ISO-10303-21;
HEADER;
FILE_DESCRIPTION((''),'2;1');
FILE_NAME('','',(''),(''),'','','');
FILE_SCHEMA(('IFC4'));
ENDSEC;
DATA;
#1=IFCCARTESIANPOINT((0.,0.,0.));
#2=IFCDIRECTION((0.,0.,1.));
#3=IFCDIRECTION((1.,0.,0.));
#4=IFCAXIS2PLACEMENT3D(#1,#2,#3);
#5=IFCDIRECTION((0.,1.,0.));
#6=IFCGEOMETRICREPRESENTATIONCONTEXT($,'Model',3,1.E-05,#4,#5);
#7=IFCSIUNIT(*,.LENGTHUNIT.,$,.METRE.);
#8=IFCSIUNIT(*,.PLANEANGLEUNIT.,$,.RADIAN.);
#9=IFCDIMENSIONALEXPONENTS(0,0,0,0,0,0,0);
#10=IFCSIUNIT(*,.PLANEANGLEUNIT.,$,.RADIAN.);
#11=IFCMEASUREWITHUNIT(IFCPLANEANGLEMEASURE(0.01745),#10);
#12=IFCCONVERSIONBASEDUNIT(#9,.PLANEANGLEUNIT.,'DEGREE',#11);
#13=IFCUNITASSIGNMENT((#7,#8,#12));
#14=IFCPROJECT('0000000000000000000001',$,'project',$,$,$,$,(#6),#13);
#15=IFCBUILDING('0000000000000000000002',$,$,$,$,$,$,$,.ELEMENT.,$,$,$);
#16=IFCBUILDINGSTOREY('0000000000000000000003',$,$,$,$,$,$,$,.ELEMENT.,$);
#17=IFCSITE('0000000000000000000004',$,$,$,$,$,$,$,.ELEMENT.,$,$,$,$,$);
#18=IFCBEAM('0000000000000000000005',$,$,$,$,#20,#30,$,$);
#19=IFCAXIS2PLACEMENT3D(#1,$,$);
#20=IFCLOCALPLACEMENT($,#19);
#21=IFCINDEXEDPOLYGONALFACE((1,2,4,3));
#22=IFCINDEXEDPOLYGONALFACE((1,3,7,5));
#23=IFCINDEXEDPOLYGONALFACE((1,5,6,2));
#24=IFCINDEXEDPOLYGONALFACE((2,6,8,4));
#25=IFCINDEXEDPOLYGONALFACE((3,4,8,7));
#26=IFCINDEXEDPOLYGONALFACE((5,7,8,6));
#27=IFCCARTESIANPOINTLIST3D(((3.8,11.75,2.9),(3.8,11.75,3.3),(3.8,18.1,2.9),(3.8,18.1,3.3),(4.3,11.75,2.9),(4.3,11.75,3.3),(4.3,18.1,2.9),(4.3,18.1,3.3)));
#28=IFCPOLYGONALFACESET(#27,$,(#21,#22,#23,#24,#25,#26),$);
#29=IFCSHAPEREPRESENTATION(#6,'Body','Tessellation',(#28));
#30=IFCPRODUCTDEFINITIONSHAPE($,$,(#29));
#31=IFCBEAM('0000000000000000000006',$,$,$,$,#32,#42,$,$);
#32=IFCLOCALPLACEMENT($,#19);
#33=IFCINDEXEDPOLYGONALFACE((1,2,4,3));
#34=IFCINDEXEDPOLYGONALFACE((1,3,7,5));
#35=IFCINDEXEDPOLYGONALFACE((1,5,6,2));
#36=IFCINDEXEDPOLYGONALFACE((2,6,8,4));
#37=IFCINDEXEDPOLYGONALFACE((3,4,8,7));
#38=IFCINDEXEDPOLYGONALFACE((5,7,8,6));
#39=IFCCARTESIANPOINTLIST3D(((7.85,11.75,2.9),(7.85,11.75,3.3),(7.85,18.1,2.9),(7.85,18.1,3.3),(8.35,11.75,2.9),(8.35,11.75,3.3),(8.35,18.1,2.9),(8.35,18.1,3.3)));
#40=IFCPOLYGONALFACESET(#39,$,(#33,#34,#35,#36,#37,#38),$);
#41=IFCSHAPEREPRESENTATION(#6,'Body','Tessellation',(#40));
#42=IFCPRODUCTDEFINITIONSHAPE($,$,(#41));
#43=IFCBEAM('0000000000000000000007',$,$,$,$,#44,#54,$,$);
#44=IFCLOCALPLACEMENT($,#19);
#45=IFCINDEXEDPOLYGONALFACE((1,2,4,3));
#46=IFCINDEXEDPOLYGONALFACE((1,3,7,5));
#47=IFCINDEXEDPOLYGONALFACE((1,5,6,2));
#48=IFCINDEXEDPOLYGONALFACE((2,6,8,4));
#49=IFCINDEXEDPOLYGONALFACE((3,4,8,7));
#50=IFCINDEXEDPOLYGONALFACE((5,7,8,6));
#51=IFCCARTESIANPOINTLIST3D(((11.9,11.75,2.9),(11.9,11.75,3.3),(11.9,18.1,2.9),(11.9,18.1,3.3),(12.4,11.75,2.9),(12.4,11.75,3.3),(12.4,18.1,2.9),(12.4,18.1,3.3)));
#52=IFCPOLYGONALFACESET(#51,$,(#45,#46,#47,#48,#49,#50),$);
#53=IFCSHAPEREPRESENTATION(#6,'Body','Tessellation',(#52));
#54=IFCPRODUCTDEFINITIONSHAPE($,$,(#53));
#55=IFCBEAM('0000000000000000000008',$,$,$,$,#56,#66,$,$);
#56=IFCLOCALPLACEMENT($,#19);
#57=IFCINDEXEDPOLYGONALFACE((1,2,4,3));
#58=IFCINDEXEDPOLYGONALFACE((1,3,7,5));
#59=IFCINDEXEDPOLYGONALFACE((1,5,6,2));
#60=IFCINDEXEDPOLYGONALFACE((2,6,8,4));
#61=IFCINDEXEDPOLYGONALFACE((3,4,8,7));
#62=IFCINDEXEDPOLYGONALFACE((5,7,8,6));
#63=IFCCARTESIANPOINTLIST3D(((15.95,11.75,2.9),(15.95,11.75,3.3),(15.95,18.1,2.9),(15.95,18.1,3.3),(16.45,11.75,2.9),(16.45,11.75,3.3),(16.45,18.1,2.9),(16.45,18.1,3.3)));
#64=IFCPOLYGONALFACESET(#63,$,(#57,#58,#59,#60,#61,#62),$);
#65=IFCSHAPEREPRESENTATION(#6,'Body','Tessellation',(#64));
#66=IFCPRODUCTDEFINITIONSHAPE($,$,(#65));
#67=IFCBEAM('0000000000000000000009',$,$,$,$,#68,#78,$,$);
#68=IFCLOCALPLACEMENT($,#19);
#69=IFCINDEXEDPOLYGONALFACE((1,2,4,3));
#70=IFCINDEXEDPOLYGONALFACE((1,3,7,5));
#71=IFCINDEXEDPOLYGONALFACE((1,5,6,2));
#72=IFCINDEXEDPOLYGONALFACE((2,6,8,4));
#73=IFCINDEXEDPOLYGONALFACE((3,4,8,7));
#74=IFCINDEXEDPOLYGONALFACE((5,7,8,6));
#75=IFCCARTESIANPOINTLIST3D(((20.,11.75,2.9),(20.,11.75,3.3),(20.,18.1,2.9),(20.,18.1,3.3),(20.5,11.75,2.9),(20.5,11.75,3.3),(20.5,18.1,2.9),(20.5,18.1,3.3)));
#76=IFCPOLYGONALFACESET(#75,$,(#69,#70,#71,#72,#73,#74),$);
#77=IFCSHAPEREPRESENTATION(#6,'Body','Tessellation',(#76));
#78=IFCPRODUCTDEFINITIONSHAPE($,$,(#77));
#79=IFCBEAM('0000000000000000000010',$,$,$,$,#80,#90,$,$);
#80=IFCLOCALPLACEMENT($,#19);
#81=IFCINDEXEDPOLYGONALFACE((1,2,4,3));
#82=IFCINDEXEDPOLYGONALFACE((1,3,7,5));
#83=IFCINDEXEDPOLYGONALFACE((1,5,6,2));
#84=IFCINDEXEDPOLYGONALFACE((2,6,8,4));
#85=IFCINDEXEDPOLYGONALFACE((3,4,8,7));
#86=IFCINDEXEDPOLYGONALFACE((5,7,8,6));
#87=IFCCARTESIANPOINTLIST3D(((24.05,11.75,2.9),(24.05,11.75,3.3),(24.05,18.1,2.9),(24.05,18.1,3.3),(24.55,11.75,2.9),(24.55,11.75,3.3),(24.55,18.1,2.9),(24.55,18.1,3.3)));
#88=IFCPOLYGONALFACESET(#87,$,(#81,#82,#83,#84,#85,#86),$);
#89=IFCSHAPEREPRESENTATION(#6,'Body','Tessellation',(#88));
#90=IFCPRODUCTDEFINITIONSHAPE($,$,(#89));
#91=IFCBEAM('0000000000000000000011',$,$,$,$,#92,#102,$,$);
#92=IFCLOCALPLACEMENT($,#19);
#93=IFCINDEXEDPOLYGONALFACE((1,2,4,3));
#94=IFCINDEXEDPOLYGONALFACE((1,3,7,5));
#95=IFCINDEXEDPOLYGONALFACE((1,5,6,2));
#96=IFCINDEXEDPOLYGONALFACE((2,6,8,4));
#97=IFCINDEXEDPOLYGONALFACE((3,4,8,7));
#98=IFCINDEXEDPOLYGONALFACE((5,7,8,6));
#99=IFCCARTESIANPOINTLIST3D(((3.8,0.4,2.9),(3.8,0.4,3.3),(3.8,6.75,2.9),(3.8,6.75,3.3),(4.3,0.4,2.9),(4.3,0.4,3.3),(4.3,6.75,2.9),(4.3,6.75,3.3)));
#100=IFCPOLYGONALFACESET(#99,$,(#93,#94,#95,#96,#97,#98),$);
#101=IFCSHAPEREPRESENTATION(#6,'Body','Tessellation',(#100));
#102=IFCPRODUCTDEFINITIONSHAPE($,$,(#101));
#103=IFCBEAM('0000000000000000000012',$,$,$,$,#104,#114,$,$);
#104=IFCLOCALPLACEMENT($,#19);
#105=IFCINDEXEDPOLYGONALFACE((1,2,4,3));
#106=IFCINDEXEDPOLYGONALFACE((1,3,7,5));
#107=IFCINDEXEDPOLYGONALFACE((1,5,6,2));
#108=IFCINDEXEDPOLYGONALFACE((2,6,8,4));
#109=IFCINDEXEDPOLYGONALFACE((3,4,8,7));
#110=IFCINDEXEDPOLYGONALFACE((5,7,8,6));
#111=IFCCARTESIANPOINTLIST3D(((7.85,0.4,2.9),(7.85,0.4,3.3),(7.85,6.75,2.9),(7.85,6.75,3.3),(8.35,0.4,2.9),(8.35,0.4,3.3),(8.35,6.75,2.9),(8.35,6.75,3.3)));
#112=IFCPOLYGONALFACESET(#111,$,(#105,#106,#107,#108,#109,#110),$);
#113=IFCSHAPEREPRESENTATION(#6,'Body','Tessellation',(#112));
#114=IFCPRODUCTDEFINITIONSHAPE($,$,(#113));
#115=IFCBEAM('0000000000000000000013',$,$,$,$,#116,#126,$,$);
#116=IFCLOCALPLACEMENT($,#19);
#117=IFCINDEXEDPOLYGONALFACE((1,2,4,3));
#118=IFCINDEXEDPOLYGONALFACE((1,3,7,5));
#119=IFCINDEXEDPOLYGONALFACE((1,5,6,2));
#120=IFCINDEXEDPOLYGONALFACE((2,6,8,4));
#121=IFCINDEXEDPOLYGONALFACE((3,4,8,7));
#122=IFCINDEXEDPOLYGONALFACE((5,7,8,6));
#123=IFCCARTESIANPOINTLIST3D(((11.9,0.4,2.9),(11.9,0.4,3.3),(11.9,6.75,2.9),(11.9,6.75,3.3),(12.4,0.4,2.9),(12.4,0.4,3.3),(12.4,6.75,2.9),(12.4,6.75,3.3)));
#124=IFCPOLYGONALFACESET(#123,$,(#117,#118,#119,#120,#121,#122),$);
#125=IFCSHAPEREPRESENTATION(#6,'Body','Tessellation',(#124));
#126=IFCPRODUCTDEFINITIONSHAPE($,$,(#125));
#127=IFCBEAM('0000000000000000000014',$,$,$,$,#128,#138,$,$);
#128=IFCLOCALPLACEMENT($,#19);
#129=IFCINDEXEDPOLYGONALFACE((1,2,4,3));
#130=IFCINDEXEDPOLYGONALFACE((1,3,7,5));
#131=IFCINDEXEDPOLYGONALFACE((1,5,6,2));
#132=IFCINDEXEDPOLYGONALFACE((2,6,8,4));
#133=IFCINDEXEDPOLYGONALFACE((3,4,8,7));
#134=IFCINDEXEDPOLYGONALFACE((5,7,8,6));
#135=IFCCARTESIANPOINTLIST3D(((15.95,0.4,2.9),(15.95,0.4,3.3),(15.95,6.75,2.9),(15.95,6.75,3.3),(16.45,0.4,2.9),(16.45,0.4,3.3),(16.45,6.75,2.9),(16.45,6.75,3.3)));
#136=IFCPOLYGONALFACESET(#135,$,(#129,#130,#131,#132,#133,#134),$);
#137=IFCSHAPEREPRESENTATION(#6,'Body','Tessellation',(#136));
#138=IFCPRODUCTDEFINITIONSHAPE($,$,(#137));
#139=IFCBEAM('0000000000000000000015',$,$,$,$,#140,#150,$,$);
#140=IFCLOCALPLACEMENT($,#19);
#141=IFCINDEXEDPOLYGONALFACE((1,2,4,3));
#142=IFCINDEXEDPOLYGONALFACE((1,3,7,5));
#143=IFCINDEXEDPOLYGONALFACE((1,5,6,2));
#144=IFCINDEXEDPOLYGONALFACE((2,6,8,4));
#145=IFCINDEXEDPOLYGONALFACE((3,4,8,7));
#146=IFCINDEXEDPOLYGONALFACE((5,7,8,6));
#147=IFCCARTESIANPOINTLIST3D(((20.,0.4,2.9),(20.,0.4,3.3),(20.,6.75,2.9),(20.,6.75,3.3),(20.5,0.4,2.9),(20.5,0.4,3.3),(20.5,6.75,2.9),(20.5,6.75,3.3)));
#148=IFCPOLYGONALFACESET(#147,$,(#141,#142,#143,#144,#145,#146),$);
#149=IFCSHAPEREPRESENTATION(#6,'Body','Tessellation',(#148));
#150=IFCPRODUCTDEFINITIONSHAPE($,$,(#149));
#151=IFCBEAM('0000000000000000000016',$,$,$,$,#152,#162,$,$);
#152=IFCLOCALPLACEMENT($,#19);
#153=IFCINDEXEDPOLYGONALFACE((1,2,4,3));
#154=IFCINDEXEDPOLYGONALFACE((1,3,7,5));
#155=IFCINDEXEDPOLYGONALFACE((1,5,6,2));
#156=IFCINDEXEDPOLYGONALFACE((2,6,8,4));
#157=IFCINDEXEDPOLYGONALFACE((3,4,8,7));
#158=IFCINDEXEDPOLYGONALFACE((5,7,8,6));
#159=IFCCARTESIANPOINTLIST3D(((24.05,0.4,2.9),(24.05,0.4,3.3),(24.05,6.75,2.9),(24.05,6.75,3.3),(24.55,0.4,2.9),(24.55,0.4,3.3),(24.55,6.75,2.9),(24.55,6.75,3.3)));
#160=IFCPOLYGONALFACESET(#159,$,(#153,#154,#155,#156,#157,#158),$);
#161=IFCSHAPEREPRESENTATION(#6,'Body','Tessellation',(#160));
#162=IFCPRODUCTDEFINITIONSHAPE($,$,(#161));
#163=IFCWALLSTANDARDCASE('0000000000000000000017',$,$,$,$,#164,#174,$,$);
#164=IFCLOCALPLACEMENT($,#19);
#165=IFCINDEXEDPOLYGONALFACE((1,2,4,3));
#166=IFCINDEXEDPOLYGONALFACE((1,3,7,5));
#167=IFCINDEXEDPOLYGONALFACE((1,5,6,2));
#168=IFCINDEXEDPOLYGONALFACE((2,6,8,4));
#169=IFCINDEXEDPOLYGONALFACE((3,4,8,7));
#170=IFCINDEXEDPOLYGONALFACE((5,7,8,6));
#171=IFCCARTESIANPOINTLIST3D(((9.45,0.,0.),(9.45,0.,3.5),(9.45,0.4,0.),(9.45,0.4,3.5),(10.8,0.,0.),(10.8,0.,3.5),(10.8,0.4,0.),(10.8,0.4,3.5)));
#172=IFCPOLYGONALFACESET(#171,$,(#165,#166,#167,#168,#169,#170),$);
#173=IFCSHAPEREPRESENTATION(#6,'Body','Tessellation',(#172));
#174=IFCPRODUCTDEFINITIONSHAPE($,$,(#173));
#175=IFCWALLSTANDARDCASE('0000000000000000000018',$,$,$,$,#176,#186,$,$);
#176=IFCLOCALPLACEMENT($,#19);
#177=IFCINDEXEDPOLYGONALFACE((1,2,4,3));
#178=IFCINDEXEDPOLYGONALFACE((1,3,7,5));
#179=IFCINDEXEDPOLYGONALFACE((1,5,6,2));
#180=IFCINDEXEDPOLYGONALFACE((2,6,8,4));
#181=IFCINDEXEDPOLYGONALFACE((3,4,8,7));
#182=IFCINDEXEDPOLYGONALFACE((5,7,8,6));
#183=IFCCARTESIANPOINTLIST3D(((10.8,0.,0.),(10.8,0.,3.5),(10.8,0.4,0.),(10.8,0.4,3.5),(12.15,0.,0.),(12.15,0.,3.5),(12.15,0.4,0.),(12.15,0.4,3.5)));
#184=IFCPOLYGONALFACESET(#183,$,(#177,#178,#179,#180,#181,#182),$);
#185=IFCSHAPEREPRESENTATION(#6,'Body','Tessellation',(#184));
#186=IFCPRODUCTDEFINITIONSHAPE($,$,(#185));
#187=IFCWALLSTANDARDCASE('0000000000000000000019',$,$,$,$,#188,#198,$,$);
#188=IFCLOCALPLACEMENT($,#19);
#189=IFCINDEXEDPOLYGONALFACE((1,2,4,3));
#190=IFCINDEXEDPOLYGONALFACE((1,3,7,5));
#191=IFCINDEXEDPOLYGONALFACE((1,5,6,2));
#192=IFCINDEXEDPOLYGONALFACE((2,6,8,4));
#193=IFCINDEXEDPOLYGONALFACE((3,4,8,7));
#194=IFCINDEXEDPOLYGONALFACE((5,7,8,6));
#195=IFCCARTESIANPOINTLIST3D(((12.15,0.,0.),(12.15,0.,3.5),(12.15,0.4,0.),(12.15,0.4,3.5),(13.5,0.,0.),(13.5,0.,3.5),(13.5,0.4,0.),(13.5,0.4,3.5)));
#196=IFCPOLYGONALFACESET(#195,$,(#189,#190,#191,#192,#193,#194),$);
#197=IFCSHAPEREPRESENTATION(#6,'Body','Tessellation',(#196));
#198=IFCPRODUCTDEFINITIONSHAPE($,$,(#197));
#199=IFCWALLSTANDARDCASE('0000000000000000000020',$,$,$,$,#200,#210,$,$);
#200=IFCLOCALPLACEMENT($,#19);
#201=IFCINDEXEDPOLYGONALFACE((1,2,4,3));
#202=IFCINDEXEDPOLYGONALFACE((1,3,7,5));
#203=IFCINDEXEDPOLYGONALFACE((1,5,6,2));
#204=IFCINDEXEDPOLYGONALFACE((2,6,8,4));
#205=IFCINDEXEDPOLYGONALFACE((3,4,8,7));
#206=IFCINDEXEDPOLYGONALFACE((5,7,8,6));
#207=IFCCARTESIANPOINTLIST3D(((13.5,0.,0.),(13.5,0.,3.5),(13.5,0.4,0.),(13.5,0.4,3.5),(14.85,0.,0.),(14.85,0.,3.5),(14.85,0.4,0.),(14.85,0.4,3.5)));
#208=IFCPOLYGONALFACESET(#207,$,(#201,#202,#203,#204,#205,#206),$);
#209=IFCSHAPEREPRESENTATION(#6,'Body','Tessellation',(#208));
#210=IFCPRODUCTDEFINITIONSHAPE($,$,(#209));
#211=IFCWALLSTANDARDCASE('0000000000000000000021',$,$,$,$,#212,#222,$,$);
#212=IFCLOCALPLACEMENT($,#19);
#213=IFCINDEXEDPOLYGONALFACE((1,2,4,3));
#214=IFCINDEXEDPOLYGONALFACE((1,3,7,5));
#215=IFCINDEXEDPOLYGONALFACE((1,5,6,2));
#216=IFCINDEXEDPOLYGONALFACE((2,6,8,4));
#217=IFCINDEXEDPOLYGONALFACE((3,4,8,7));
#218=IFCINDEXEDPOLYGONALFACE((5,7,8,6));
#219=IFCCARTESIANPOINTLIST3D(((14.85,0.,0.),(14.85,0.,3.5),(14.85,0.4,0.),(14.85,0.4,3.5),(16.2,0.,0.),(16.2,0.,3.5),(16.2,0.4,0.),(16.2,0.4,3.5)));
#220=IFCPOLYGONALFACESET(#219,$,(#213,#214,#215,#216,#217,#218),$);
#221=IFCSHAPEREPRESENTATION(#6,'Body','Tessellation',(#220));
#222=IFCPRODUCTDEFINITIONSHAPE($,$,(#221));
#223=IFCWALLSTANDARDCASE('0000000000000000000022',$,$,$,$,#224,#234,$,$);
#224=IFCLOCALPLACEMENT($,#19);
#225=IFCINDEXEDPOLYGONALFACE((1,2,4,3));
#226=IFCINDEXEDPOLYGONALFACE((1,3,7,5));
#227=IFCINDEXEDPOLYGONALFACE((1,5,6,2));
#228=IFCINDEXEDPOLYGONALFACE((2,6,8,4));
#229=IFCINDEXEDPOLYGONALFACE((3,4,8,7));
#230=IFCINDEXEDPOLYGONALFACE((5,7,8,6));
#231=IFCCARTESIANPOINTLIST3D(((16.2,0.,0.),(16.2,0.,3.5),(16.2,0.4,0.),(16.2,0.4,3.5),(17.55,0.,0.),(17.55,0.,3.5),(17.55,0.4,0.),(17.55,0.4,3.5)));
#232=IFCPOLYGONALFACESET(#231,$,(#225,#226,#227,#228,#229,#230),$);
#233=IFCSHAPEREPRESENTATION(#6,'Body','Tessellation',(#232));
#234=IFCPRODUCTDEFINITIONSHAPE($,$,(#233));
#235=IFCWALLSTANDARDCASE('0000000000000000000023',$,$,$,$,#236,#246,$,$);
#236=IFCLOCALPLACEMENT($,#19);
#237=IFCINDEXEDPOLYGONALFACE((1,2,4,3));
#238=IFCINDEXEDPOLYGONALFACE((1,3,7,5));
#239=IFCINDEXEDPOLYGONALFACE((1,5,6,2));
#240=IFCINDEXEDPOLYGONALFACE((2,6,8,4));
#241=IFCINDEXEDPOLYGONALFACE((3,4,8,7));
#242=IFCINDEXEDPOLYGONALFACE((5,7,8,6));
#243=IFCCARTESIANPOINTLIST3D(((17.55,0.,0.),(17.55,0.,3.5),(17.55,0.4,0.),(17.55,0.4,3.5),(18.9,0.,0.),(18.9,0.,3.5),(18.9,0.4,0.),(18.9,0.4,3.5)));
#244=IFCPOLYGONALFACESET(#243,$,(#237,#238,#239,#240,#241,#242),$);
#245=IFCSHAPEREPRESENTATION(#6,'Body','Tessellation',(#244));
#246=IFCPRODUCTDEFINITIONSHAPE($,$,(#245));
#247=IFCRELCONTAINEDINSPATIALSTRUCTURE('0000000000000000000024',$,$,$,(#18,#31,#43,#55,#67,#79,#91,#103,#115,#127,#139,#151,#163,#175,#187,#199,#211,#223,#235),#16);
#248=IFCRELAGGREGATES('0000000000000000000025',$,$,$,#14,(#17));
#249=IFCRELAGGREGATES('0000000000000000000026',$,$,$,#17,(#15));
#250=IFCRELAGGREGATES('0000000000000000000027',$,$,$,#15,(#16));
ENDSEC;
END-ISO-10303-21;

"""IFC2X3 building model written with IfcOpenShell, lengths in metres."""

from ifc_helpers import new_model, entity, si_unit, converted_unit, direction, frame, origin_with_axes, place, context, project, spatial, polyline, outline, extrude, element, save


model = new_model("IFC2X3")

# Units and contexts
model_context = context("Model", 3, precision=1e-05, world=origin_with_axes(), true_north=direction((0.0, 1.0, 0.0)))
ifc_project = project(units=[si_unit("LENGTHUNIT", "METRE"), si_unit("PLANEANGLEUNIT", "RADIAN"), converted_unit("PLANEANGLEUNIT", "DEGREE", entity("IfcPlaneAngleMeasure", 0.01745), si_unit("PLANEANGLEUNIT", "RADIAN"), dimensions=[0, 0, 0, 0, 0, 0, 0])], contexts=[model_context])

# Site, building, storey
site = spatial("IfcSite", under=ifc_project, CompositionType="ELEMENT")
building = spatial("IfcBuilding", under=site, CompositionType="ELEMENT")
storey = spatial("IfcBuildingStorey", under=building, CompositionType="ELEMENT")

# Beams
for number, where, z_axis, x_axis in (
    (1, (4.05, 18.1, 3.1), (0.0, -1.0, 0.0), (-1.0, 0.0, 0.0)),
    (2, (8.1, 18.1, 3.1), (0.0, -1.0, 0.0), (-1.0, 0.0, 0.0)),
    (3, (12.15, 18.1, 3.1), (0.0, -1.0, 0.0), (-1.0, 0.0, 0.0)),
    (4, (16.2, 18.1, 3.1), (0.0, -1.0, 0.0), (-1.0, 0.0, 0.0)),
    (5, (20.25, 18.1, 3.1), (0.0, -1.0, 0.0), (-1.0, 0.0, 0.0)),
    (6, (24.3, 18.1, 3.1), (0.0, -1.0, 0.0), (-1.0, 0.0, 0.0)),
    (7, (4.05, 0.4, 3.1), (0.0, 1.0, 0.0), (1.0, 0.0, 0.0)),
    (8, (8.1, 0.4, 3.1), (0.0, 1.0, 0.0), (1.0, 0.0, 0.0)),
    (9, (12.15, 0.4, 3.1), (0.0, 1.0, 0.0), (1.0, 0.0, 0.0)),
    (10, (16.2, 0.4, 3.1), (0.0, 1.0, 0.0), (1.0, 0.0, 0.0)),
    (11, (20.25, 0.4, 3.1), (0.0, 1.0, 0.0), (1.0, 0.0, 0.0)),
    (12, (24.3, 0.4, 3.1), (0.0, 1.0, 0.0), (1.0, 0.0, 0.0)),
):
    element("IfcBeam", number, at=place(None, frame(where, z_axis=z_axis, x_axis=x_axis)), inside=storey, context=model_context, shape_type="SweptSolid", body=[
        extrude(outline(polyline([(-0.25, -0.2, 0.0), (0.25, -0.2, 0.0), (0.25, 0.2, 0.0), (-0.25, 0.2, 0.0)])), origin_with_axes(), (0.0, 0.0, 1.0), 6.35),
    ])

# Walls
wall_1_placement = place(None, origin_with_axes())
element("IfcWallStandardCase", 13, at=wall_1_placement, inside=storey, context=model_context, shape_type="SweptSolid", body=[
    extrude(outline(polyline([(9.45, 0.0, 0.0), (10.8, 0.0, 0.0), (10.8, 0.4, 0.0), (9.45, 0.4, 0.0)])), origin_with_axes(), (0.0, 0.0, 1.0), 3.5),
])
wall_2_placement = place(None, origin_with_axes())
element("IfcWallStandardCase", 14, at=wall_2_placement, inside=storey, context=model_context, shape_type="SweptSolid", body=[
    extrude(outline(polyline([(10.8, 0.0, 0.0), (12.15, 0.0, 0.0), (12.15, 0.4, 0.0), (10.8, 0.4, 0.0)])), origin_with_axes(), (0.0, 0.0, 1.0), 3.5),
])
wall_3_placement = place(None, origin_with_axes())
element("IfcWallStandardCase", 15, at=wall_3_placement, inside=storey, context=model_context, shape_type="SweptSolid", body=[
    extrude(outline(polyline([(12.15, 0.0, 0.0), (13.5, 0.0, 0.0), (13.5, 0.4, 0.0), (12.15, 0.4, 0.0)])), origin_with_axes(), (0.0, 0.0, 1.0), 3.5),
])
wall_4_placement = place(None, origin_with_axes())
element("IfcWallStandardCase", 16, at=wall_4_placement, inside=storey, context=model_context, shape_type="SweptSolid", body=[
    extrude(outline(polyline([(13.5, 0.0, 0.0), (14.85, 0.0, 0.0), (14.85, 0.4, 0.0), (13.5, 0.4, 0.0)])), origin_with_axes(), (0.0, 0.0, 1.0), 3.5),
])
wall_5_placement = place(None, origin_with_axes())
element("IfcWallStandardCase", 17, at=wall_5_placement, inside=storey, context=model_context, shape_type="SweptSolid", body=[
    extrude(outline(polyline([(14.85, 0.0, 0.0), (16.2, 0.0, 0.0), (16.2, 0.4, 0.0), (14.85, 0.4, 0.0)])), origin_with_axes(), (0.0, 0.0, 1.0), 3.5),
])
wall_6_placement = place(None, origin_with_axes())
element("IfcWallStandardCase", 18, at=wall_6_placement, inside=storey, context=model_context, shape_type="SweptSolid", body=[
    extrude(outline(polyline([(16.2, 0.0, 0.0), (17.55, 0.0, 0.0), (17.55, 0.4, 0.0), (16.2, 0.4, 0.0)])), origin_with_axes(), (0.0, 0.0, 1.0), 3.5),
])
wall_7_placement = place(None, origin_with_axes())
element("IfcWallStandardCase", 19, at=wall_7_placement, inside=storey, context=model_context, shape_type="SweptSolid", body=[
    extrude(outline(polyline([(17.55, 0.0, 0.0), (18.9, 0.0, 0.0), (18.9, 0.4, 0.0), (17.55, 0.4, 0.0)])), origin_with_axes(), (0.0, 0.0, 1.0), 3.5),
])

save(model, "model.ifc")
